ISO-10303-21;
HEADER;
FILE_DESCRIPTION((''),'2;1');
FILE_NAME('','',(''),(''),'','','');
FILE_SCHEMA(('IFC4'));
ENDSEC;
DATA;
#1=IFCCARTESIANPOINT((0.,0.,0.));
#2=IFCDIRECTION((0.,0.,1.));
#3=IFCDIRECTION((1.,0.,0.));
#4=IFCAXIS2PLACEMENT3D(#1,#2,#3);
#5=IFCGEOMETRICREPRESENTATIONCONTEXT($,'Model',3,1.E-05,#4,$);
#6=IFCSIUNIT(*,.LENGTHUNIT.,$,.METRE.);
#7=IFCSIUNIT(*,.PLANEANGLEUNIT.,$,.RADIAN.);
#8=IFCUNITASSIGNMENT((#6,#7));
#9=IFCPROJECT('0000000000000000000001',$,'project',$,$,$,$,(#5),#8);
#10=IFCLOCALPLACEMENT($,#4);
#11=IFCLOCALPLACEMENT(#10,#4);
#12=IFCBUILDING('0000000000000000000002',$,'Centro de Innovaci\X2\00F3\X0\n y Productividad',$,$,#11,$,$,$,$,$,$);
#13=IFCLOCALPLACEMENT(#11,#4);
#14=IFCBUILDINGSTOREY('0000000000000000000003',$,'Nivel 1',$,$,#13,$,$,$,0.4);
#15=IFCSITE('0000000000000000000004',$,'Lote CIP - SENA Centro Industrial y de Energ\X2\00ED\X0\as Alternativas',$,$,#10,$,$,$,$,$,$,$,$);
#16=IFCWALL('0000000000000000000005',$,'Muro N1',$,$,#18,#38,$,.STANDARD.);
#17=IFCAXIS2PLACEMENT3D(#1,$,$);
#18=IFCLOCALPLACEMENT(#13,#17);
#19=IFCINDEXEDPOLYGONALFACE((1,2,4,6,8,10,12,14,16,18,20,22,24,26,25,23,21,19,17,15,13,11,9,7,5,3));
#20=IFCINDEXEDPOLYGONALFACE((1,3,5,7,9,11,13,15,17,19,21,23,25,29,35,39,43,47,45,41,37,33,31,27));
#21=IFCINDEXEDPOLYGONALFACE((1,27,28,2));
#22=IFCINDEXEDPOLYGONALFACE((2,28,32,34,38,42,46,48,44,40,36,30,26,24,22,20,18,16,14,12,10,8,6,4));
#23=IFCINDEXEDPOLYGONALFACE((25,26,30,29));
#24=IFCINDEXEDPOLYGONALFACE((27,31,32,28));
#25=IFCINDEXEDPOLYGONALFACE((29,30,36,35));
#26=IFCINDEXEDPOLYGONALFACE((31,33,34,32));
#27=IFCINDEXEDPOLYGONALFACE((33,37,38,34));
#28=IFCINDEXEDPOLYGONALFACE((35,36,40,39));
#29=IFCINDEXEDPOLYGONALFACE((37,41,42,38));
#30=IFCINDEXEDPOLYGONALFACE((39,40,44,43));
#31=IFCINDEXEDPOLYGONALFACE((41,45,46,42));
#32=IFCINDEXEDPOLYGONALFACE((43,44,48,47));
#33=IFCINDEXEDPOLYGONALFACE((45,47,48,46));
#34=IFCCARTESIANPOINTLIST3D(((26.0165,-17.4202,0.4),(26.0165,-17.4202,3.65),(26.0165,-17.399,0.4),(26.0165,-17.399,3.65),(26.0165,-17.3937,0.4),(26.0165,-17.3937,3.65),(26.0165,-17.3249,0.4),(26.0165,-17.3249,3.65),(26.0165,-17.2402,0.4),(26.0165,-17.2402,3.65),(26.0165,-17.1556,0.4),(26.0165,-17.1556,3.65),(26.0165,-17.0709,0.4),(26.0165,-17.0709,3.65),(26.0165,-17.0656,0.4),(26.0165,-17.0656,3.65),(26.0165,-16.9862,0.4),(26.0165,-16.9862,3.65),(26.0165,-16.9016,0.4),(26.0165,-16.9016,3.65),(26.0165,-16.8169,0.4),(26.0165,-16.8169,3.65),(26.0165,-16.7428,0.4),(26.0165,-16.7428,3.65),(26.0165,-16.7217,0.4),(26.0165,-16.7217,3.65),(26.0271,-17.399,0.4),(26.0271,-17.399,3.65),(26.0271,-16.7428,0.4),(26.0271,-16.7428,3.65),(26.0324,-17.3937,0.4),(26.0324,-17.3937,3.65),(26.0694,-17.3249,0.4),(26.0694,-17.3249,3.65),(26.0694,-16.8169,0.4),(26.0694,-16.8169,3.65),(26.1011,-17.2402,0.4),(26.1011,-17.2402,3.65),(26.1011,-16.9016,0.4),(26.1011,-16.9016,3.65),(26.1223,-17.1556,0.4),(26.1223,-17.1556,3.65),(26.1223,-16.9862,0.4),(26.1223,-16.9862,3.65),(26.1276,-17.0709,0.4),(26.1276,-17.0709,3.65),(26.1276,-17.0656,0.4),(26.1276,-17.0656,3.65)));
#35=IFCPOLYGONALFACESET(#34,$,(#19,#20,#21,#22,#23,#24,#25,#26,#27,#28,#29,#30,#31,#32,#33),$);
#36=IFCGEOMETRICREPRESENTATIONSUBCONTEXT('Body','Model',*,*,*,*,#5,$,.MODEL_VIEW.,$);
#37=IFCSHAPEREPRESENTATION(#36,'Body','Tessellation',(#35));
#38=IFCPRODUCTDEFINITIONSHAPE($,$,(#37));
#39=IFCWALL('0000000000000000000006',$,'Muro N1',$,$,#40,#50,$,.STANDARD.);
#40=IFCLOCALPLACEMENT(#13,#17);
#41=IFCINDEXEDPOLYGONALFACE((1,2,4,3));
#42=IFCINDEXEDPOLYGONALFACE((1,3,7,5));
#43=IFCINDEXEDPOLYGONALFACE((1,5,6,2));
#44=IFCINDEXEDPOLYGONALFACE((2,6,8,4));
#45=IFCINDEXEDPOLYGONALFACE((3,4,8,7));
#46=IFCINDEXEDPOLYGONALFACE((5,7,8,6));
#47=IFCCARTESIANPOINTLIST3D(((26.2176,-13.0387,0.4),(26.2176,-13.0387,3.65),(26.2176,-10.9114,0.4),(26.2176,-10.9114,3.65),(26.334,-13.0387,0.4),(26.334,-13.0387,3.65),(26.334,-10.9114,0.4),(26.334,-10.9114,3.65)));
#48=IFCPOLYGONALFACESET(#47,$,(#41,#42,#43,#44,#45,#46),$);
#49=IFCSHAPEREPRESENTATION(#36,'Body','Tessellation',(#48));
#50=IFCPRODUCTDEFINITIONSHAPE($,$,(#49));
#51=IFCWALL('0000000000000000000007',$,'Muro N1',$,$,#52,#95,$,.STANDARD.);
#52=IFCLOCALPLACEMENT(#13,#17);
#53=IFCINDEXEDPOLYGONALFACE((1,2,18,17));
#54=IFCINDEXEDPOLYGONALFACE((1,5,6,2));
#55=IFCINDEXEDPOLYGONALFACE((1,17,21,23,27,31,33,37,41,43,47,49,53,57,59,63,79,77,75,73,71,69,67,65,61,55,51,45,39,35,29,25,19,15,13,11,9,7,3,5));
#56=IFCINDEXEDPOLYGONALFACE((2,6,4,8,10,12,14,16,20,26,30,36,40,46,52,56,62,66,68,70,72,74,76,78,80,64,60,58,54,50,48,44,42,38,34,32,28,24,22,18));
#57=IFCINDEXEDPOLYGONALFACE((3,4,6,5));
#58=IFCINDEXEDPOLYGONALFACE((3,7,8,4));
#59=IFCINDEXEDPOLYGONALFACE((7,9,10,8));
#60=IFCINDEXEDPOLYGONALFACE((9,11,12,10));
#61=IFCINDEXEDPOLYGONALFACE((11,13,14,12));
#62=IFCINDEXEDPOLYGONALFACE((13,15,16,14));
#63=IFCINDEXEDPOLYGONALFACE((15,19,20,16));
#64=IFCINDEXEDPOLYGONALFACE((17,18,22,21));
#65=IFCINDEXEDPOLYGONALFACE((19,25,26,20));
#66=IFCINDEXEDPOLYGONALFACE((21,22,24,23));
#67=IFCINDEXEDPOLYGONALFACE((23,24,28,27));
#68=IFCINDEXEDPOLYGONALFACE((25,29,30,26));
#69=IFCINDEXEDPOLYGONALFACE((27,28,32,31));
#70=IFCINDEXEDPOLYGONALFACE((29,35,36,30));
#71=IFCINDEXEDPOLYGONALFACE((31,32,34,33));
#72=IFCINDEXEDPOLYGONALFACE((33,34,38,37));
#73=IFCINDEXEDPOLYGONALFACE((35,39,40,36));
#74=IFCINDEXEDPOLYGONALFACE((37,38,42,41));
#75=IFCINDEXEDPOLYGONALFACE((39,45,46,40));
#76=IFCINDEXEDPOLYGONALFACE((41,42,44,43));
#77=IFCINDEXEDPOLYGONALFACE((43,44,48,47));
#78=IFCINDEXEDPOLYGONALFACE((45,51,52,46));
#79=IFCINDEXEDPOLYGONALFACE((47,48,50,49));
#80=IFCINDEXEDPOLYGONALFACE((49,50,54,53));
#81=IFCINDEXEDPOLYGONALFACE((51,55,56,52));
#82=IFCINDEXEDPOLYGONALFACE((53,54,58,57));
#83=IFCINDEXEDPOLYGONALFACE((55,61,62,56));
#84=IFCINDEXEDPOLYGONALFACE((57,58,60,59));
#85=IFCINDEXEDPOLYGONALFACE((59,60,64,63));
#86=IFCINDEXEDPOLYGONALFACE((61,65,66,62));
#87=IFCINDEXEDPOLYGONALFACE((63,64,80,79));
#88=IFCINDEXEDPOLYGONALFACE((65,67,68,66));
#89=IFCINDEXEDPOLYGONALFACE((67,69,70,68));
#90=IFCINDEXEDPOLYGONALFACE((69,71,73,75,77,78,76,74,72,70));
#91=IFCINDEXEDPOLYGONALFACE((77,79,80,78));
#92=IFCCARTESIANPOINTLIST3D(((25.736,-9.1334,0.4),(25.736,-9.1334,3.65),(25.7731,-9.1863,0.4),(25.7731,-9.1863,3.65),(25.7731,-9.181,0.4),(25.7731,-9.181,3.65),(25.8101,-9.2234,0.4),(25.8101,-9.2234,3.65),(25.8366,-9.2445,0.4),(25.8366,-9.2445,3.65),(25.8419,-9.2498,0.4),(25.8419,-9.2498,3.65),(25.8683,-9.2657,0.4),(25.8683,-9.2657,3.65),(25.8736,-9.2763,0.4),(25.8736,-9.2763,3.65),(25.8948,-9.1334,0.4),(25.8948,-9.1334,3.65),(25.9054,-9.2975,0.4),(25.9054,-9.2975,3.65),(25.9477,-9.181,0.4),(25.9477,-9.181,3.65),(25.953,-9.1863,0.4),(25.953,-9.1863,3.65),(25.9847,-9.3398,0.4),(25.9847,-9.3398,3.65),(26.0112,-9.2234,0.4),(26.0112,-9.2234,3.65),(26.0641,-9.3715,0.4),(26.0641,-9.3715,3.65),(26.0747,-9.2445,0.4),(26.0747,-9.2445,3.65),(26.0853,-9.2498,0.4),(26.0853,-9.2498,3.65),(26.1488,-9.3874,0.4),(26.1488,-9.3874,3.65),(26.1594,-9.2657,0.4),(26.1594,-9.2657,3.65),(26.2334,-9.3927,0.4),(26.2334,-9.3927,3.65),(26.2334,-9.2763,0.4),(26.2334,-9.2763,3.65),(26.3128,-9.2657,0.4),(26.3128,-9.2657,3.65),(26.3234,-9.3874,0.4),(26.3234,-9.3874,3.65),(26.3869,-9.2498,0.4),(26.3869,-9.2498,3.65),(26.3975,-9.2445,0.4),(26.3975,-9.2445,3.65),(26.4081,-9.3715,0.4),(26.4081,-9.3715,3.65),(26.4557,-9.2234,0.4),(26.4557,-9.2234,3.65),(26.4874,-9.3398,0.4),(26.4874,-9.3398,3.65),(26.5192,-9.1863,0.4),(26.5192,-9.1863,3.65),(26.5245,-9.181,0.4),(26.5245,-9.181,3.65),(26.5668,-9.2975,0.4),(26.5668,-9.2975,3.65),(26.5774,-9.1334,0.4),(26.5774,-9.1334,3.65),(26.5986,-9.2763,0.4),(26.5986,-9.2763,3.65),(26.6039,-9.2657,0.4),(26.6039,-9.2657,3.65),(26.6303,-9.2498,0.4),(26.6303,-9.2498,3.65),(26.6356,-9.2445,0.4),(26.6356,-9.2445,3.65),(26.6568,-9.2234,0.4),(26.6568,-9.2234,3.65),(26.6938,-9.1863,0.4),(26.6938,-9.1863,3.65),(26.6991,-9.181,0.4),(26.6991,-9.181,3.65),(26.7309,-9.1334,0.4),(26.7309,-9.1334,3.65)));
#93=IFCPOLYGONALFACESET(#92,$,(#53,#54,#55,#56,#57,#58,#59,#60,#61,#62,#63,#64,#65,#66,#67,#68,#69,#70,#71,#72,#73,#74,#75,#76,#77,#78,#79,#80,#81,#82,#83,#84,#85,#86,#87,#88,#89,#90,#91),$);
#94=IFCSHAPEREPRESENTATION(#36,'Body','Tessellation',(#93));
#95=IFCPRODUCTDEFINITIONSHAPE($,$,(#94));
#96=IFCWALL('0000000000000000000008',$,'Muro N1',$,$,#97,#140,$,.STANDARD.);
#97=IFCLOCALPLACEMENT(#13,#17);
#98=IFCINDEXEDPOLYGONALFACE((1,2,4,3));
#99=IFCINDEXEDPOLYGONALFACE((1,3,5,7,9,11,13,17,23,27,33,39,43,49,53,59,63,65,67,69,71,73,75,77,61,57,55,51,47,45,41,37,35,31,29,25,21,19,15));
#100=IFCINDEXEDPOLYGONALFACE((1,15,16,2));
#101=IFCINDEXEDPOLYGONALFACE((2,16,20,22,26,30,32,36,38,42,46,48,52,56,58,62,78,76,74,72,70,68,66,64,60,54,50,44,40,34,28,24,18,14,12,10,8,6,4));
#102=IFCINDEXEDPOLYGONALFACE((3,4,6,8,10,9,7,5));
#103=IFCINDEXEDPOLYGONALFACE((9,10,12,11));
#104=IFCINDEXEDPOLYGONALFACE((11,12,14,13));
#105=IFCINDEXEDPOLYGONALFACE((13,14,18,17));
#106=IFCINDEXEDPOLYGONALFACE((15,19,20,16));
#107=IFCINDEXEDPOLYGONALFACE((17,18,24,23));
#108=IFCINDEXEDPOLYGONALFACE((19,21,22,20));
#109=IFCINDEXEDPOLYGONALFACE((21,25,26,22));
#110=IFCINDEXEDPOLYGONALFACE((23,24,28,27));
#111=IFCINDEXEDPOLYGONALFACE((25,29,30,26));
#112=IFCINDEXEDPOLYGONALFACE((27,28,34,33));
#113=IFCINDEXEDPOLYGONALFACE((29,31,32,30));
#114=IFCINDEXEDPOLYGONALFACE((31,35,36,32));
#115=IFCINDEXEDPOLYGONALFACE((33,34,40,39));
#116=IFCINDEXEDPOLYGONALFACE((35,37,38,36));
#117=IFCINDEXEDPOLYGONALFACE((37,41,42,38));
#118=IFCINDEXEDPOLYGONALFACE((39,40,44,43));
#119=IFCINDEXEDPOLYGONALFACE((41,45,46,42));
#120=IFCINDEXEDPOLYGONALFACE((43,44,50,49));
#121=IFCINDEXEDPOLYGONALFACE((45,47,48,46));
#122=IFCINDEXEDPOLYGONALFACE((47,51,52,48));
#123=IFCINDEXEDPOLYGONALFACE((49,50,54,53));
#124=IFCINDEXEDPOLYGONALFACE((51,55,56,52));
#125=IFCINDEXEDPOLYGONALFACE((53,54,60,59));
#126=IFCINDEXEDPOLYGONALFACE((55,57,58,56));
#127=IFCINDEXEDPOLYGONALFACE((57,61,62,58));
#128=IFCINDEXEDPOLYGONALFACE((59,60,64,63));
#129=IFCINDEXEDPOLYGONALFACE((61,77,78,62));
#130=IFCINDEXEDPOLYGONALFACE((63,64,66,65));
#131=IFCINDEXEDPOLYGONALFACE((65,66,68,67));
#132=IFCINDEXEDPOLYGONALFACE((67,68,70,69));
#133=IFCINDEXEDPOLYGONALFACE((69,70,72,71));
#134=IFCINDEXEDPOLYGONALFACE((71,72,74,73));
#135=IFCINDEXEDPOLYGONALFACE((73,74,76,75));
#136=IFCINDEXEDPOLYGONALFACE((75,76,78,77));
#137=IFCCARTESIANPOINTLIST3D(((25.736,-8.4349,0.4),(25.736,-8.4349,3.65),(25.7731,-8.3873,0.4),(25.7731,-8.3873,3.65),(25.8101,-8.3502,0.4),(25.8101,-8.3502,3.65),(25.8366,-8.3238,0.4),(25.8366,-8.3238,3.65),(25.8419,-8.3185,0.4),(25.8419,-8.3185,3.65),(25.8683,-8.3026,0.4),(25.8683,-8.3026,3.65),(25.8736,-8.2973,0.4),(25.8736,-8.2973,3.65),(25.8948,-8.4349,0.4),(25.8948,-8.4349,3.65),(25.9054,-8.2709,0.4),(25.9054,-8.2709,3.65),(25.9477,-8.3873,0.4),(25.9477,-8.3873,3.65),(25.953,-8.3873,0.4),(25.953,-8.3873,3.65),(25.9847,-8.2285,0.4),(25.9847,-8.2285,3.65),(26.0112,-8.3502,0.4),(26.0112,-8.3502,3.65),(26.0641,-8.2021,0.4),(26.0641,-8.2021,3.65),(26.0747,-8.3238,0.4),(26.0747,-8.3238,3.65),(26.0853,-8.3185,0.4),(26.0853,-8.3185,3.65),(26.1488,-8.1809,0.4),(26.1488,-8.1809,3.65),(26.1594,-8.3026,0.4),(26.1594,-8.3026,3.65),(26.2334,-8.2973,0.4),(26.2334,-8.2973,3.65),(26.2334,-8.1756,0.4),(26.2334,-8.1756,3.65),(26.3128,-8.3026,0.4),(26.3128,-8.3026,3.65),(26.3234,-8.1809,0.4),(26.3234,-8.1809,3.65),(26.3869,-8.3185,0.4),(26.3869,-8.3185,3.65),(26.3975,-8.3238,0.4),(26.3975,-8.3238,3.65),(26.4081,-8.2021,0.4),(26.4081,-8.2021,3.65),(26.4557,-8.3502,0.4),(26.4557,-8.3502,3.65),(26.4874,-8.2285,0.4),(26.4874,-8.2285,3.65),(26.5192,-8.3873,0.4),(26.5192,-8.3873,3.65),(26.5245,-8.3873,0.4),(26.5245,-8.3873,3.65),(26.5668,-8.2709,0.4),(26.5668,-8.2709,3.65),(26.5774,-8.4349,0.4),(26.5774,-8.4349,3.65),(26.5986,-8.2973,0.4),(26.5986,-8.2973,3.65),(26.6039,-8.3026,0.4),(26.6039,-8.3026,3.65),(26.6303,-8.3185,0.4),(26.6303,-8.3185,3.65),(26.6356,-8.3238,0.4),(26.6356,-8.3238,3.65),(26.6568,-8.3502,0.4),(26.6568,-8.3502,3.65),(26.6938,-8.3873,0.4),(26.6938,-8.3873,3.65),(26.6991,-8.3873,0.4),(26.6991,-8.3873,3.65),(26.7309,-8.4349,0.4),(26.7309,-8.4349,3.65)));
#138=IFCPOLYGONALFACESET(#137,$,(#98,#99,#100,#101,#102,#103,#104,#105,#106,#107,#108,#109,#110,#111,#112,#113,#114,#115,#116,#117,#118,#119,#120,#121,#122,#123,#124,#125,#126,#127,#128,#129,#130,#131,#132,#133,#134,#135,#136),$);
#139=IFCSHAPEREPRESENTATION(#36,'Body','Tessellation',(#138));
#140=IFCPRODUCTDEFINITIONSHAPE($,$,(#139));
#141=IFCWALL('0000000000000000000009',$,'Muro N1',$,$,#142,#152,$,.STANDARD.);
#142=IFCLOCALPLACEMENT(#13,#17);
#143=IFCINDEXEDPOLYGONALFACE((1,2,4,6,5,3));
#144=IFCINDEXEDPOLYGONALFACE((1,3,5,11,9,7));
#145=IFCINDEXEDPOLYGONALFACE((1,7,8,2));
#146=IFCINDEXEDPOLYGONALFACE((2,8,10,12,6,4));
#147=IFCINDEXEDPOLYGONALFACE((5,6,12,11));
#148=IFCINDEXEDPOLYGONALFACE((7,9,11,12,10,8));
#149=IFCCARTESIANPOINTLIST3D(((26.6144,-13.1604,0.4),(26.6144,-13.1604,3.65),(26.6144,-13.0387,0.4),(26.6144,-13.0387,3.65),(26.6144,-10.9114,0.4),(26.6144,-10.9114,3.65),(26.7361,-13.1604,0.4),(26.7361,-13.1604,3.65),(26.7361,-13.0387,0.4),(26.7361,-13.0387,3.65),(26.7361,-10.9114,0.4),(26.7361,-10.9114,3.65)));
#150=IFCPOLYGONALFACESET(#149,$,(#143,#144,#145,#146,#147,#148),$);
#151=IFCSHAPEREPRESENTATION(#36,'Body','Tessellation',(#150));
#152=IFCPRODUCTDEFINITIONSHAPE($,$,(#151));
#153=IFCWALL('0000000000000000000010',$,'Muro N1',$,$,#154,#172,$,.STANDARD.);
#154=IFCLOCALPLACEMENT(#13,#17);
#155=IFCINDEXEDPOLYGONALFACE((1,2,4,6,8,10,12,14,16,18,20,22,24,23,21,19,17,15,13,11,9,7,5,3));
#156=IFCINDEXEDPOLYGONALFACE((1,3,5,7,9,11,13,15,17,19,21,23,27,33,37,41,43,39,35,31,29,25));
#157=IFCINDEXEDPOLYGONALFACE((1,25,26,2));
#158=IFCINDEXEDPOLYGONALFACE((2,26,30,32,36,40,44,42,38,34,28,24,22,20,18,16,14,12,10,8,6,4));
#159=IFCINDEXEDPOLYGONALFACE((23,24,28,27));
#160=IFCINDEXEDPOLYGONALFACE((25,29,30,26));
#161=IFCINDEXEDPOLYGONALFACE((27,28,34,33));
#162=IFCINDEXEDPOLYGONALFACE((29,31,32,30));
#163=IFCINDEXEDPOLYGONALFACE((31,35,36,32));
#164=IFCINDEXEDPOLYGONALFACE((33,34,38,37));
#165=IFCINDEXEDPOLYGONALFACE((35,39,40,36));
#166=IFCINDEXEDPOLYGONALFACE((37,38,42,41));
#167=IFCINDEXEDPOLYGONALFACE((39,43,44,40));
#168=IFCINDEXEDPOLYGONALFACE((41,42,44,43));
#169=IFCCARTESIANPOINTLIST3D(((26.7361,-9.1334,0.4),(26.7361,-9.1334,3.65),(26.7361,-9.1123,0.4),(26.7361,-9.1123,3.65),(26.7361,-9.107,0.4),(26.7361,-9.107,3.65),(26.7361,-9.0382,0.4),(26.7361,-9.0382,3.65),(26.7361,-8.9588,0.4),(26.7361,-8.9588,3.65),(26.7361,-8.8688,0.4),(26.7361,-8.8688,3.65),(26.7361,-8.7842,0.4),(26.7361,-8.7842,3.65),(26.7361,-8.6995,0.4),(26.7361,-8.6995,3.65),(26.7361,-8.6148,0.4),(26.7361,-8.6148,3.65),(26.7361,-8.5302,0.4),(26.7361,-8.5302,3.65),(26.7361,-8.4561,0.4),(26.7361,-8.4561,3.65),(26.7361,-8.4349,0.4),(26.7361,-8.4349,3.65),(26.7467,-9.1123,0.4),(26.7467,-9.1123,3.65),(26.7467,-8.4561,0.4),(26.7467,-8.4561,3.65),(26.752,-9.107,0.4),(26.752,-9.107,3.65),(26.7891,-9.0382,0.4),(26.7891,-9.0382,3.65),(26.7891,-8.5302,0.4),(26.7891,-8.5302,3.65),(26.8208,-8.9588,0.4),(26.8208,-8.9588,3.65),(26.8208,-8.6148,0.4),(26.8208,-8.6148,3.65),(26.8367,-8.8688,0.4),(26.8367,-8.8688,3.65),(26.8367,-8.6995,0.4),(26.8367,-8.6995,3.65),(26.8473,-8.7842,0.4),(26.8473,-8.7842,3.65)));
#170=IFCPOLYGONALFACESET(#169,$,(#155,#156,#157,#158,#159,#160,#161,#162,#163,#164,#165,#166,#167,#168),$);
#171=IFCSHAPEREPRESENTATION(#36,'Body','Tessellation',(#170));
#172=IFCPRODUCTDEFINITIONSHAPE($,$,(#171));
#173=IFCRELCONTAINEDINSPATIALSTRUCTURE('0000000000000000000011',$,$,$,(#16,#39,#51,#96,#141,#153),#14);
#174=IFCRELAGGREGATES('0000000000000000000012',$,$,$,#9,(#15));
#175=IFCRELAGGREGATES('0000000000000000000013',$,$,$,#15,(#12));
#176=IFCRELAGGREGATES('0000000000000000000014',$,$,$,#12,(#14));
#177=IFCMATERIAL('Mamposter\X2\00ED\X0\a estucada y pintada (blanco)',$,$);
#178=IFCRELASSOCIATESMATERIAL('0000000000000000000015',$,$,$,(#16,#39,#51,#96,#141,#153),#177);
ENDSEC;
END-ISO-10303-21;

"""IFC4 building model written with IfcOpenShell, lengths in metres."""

from ifc_helpers import new_model, si_unit, frame, origin_with_axes, place, context, subcontext, project, spatial, polyline, outline, extrude, material, element, save


model = new_model("IFC4")

# Units and contexts
model_context = context("Model", 3, precision=1e-05, world=origin_with_axes())
body_context = subcontext(model_context, "Body", "Model", "MODEL_VIEW")
ifc_project = project(units=[si_unit("LENGTHUNIT", "METRE"), si_unit("PLANEANGLEUNIT", "RADIAN")], contexts=[model_context])

# Site, building, storey
site_placement = place(None, origin_with_axes())
site = spatial("IfcSite", under=ifc_project, at=site_placement, Name="Lote CIP - SENA Centro Industrial y de Energías Alternativas")
building_placement = place(site_placement, origin_with_axes())
building = spatial("IfcBuilding", under=site, at=building_placement, Name="Centro de Innovación y Productividad")
storey_placement = place(building_placement, origin_with_axes())
storey = spatial("IfcBuildingStorey", under=building, at=storey_placement, Name="Nivel 1", Elevation=0.4)

# Walls
ifc_material = material(Name="Mampostería estucada y pintada (blanco)")
wall_1_placement = place(storey_placement, origin_with_axes())
element("IfcWall", 1, at=wall_1_placement, inside=storey, material=ifc_material, Name="Muro N1", PredefinedType="STANDARD", context=body_context, shape_type="SweptSolid", body=[
    extrude(outline(polyline([(26.0165, -17.3249), (26.0165, -17.2402), (26.0165, -17.1556), (26.0165, -17.0709), (26.0165, -17.0656), (26.0165, -16.9862), (26.0165, -16.9016), (26.0165, -16.8169), (26.0165, -16.7428), (26.0165, -16.7217), (26.0271, -16.7428), (26.0694, -16.8169), (26.1011, -16.9016), (26.1223, -16.9862), (26.1276, -17.0656), (26.1276, -17.0709), (26.1223, -17.1556), (26.1011, -17.2402), (26.0694, -17.3249), (26.0324, -17.3937), (26.0271, -17.399), (26.0165, -17.4202), (26.0165, -17.399), (26.0165, -17.3937), (26.0165, -17.3249)])), frame((0.0, 0.0, 0.4)), (0.0, 0.0, 1.0), 3.25),
])
wall_2_placement = place(storey_placement, origin_with_axes())
element("IfcWall", 2, at=wall_2_placement, inside=storey, material=ifc_material, Name="Muro N1", PredefinedType="STANDARD", context=body_context, shape_type="SweptSolid", body=[
    extrude(outline(polyline([(26.2176, -10.9114), (26.334, -10.9114), (26.334, -13.0387), (26.2176, -13.0387), (26.2176, -10.9114)])), frame((0.0, 0.0, 0.4)), (0.0, 0.0, 1.0), 3.25),
])
wall_3_placement = place(storey_placement, origin_with_axes())
element("IfcWall", 3, at=wall_3_placement, inside=storey, material=ifc_material, Name="Muro N1", PredefinedType="STANDARD", context=body_context, shape_type="SweptSolid", body=[
    extrude(outline(polyline([(25.9847, -9.3398), (25.9054, -9.2975), (25.8736, -9.2763), (25.8683, -9.2657), (25.8419, -9.2498), (25.8366, -9.2445), (25.8101, -9.2234), (25.7731, -9.1863), (25.7731, -9.181), (25.736, -9.1334), (25.8948, -9.1334), (25.9477, -9.181), (25.953, -9.1863), (26.0112, -9.2234), (26.0747, -9.2445), (26.0853, -9.2498), (26.1594, -9.2657), (26.2334, -9.2763), (26.3128, -9.2657), (26.3869, -9.2498), (26.3975, -9.2445), (26.4557, -9.2234), (26.5192, -9.1863), (26.5245, -9.181), (26.5774, -9.1334), (26.7309, -9.1334), (26.6991, -9.181), (26.6938, -9.1863), (26.6568, -9.2234), (26.6356, -9.2445), (26.6303, -9.2498), (26.6039, -9.2657), (26.5986, -9.2763), (26.5668, -9.2975), (26.4874, -9.3398), (26.4081, -9.3715), (26.3234, -9.3874), (26.2334, -9.3927), (26.1488, -9.3874), (26.0641, -9.3715), (25.9847, -9.3398)])), frame((0.0, 0.0, 0.4)), (0.0, 0.0, 1.0), 3.25),
])
wall_4_placement = place(storey_placement, origin_with_axes())
element("IfcWall", 4, at=wall_4_placement, inside=storey, material=ifc_material, Name="Muro N1", PredefinedType="STANDARD", context=body_context, shape_type="SweptSolid", body=[
    extrude(outline(polyline([(25.8736, -8.2973), (25.9054, -8.2709), (25.9847, -8.2285), (26.0641, -8.2021), (26.1488, -8.1809), (26.2334, -8.1756), (26.3234, -8.1809), (26.4081, -8.2021), (26.4874, -8.2285), (26.5668, -8.2709), (26.5986, -8.2973), (26.6039, -8.3026), (26.6303, -8.3185), (26.6356, -8.3238), (26.6568, -8.3502), (26.6938, -8.3873), (26.6991, -8.3873), (26.7309, -8.4349), (26.5774, -8.4349), (26.5245, -8.3873), (26.5192, -8.3873), (26.4557, -8.3502), (26.3975, -8.3238), (26.3869, -8.3185), (26.3128, -8.3026), (26.2334, -8.2973), (26.1594, -8.3026), (26.0853, -8.3185), (26.0747, -8.3238), (26.0112, -8.3502), (25.953, -8.3873), (25.9477, -8.3873), (25.8948, -8.4349), (25.736, -8.4349), (25.7731, -8.3873), (25.8101, -8.3502), (25.8366, -8.3238), (25.8419, -8.3185), (25.8683, -8.3026), (25.8736, -8.2973)])), frame((0.0, 0.0, 0.4)), (0.0, 0.0, 1.0), 3.25),
])
wall_5_placement = place(storey_placement, origin_with_axes())
element("IfcWall", 5, at=wall_5_placement, inside=storey, material=ifc_material, Name="Muro N1", PredefinedType="STANDARD", context=body_context, shape_type="SweptSolid", body=[
    extrude(outline(polyline([(26.6144, -13.1604), (26.6144, -13.0387), (26.6144, -10.9114), (26.7361, -10.9114), (26.7361, -13.0387), (26.7361, -13.1604), (26.6144, -13.1604)])), frame((0.0, 0.0, 0.4)), (0.0, 0.0, 1.0), 3.25),
])
wall_6_placement = place(storey_placement, origin_with_axes())
element("IfcWall", 6, at=wall_6_placement, inside=storey, material=ifc_material, Name="Muro N1", PredefinedType="STANDARD", context=body_context, shape_type="SweptSolid", body=[
    extrude(outline(polyline([(26.7361, -8.6148), (26.7361, -8.5302), (26.7361, -8.4561), (26.7361, -8.4349), (26.7467, -8.4561), (26.7891, -8.5302), (26.8208, -8.6148), (26.8367, -8.6995), (26.8473, -8.7842), (26.8367, -8.8688), (26.8208, -8.9588), (26.7891, -9.0382), (26.752, -9.107), (26.7467, -9.1123), (26.7361, -9.1334), (26.7361, -9.1123), (26.7361, -9.107), (26.7361, -9.0382), (26.7361, -8.9588), (26.7361, -8.8688), (26.7361, -8.7842), (26.7361, -8.6995), (26.7361, -8.6148)])), frame((0.0, 0.0, 0.4)), (0.0, 0.0, 1.0), 3.25),
])

save(model, "model.ifc")
